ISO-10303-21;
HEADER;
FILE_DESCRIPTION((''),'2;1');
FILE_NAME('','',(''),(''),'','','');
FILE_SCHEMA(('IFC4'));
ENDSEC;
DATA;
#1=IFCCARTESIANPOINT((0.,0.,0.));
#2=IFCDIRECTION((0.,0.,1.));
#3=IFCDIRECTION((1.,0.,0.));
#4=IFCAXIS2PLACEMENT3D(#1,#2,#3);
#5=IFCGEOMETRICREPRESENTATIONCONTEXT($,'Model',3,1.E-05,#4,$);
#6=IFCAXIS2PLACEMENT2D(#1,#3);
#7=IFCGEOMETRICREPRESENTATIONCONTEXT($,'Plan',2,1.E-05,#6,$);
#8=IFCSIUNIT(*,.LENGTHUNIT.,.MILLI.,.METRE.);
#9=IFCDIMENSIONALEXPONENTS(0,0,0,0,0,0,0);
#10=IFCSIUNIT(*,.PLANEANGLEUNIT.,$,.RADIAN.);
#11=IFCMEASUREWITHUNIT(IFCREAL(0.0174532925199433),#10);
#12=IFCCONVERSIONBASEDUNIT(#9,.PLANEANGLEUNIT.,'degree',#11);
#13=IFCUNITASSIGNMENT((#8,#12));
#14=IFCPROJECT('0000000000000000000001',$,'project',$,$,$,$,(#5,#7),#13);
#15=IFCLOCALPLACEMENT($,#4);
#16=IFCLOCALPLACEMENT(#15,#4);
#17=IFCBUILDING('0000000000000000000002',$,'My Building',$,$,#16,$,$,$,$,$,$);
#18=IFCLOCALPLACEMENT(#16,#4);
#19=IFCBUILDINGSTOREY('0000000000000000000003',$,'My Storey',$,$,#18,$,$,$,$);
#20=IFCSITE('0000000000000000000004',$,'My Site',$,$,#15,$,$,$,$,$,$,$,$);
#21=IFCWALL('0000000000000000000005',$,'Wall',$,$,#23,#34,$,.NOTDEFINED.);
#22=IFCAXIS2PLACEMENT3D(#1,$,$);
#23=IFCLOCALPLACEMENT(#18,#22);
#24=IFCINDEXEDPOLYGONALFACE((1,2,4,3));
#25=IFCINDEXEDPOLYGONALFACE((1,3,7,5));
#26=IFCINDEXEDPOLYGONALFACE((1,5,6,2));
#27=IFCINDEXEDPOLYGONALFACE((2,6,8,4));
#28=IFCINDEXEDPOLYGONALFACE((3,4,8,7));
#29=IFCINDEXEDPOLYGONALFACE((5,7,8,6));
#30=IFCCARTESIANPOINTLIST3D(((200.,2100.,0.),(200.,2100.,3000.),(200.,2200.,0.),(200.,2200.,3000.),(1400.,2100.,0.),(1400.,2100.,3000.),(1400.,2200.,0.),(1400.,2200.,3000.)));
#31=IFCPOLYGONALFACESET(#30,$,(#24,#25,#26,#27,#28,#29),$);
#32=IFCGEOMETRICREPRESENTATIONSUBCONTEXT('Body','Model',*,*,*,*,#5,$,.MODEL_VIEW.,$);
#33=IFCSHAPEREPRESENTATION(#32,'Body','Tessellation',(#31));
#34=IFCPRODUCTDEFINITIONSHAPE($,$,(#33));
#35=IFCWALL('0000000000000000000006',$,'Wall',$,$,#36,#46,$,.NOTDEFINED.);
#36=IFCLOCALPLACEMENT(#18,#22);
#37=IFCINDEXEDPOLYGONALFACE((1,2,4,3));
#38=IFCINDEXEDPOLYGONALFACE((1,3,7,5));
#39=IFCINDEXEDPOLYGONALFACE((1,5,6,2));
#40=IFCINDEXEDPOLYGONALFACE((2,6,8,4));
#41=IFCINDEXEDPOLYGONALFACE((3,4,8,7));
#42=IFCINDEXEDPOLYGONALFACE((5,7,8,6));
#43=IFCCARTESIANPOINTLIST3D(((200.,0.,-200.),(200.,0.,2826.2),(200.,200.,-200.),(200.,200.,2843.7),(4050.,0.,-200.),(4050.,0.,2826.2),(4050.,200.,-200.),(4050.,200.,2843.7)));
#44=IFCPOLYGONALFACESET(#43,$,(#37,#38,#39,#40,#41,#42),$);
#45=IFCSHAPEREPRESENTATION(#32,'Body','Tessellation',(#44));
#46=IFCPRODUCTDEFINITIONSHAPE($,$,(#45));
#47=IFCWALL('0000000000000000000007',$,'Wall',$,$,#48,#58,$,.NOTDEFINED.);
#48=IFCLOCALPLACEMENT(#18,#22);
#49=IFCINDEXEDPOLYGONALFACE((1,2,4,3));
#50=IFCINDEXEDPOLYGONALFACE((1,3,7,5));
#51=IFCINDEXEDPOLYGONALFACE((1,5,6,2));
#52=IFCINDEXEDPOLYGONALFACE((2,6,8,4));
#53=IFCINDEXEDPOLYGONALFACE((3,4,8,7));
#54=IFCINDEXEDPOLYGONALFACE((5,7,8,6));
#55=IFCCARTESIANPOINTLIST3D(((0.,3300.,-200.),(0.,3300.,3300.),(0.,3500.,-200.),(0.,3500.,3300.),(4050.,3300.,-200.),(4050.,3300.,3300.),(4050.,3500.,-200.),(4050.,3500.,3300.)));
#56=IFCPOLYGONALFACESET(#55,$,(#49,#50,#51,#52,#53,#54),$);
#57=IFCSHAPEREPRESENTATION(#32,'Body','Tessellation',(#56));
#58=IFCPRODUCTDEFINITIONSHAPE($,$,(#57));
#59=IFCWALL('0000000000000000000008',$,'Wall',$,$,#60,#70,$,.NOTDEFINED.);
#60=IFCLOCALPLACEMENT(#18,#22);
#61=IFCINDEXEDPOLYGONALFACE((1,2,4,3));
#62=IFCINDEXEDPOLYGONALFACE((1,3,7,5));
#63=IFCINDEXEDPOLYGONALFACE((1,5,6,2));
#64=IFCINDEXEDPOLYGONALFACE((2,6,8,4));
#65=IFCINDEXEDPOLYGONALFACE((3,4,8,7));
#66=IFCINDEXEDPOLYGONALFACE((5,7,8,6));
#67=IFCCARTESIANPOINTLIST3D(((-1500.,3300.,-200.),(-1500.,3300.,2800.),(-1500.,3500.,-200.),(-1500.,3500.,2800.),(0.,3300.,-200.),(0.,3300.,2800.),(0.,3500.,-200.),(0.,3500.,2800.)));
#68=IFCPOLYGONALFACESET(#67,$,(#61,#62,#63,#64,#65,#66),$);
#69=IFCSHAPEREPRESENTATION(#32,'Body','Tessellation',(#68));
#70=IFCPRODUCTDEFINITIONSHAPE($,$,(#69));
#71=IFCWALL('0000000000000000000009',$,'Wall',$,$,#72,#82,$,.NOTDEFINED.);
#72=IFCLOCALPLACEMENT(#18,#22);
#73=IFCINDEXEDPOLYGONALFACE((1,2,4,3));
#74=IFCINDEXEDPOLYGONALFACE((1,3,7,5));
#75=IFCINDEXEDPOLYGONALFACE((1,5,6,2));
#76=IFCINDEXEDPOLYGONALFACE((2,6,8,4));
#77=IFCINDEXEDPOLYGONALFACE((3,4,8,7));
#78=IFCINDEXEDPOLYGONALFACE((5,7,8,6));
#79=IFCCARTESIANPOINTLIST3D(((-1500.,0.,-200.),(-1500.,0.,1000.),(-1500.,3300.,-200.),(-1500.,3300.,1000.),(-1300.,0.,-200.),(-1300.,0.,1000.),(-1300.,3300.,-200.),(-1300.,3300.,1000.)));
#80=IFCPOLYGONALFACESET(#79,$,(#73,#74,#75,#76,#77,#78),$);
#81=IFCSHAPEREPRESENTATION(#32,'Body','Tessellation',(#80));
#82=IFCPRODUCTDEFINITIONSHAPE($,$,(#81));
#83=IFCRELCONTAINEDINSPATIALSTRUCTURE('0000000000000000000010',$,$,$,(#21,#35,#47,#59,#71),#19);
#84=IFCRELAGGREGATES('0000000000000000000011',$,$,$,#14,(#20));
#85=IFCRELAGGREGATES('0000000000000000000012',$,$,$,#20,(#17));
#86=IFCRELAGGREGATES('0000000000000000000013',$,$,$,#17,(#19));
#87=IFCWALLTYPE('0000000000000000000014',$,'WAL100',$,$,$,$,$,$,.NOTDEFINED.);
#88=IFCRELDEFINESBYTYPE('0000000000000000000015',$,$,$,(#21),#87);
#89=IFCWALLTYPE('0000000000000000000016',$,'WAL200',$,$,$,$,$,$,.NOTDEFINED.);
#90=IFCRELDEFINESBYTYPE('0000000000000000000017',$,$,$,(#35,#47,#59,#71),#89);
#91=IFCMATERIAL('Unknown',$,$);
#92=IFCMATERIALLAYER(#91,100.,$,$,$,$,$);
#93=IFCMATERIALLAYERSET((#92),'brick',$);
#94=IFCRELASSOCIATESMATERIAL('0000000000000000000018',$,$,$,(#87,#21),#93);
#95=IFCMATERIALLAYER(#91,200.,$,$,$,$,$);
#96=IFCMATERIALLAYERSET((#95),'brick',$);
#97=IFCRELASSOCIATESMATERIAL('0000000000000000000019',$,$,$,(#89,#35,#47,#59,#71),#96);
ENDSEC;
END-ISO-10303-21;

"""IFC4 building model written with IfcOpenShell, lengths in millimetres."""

from ifc_helpers import new_model, entity, si_unit, converted_unit, frame, frame_2d, origin_with_axes, place, context, subcontext, project, spatial, indexed_curve, outline, extrude, clip, halfspace, material, layer, layer_set, layer_usage, type_object, element, save


model = new_model("IFC4")

# Units and contexts
model_context = context("Model", 3, precision=1e-05, world=origin_with_axes())
plan_context = context("Plan", 2, precision=1e-05, world=frame_2d((0.0, 0.0, 0.0), x_axis=(1.0, 0.0, 0.0)))
body_context = subcontext(model_context, "Body", "Model", "MODEL_VIEW")
ifc_project = project(units=[si_unit("LENGTHUNIT", "METRE", prefix="MILLI"), converted_unit("PLANEANGLEUNIT", "degree", entity("IfcReal", 0.0174532925199433), si_unit("PLANEANGLEUNIT", "RADIAN"), dimensions=[0, 0, 0, 0, 0, 0, 0])], contexts=[model_context, plan_context])

# Site, building, storey
site_placement = place(None, origin_with_axes())
site = spatial("IfcSite", under=ifc_project, at=site_placement, Name="My Site")
building_placement = place(site_placement, origin_with_axes())
building = spatial("IfcBuilding", under=site, at=building_placement, Name="My Building")
storey_placement = place(building_placement, origin_with_axes())
storey = spatial("IfcBuildingStorey", under=building, at=storey_placement, Name="My Storey")

# Shared definitions
ifc_material = material(Name="Unknown")

# Walls
ifc_layer_1 = layer(ifc_material, 100.0)
ifc_layer_set_1 = layer_set([ifc_layer_1], Name="brick")
ifc_layer_usage_1 = layer_usage(ifc_layer_set_1, "AXIS2", "POSITIVE", 0.0)
wall_type_1 = type_object("IfcWallType", Name="WAL100", PredefinedType="NOTDEFINED", material=ifc_layer_set_1)
wall_1_placement = place(storey_placement, frame((200.0, 2100.0, 0.0), z_axis=(0.0, 0.0, 1.0), x_axis=(1.0, 0.0, 0.0)))
element("IfcWall", 1, at=wall_1_placement, inside=storey, type_object=wall_type_1, material=ifc_layer_usage_1, Name="Wall", PredefinedType="NOTDEFINED", context=body_context, shape_type="SweptSolid", body=[
    extrude(outline(indexed_curve([(0.0, 0.0), (0.0, 100.0), (1200.0, 100.0), (1200.0, 0.0), (0.0, 0.0)], self_intersect=False)), origin_with_axes(), (0.0, 0.0, 1.0), 3000.0),
])
ifc_layer_2 = layer(ifc_material, 200.0)
ifc_layer_set_2 = layer_set([ifc_layer_2], Name="brick")
ifc_layer_usage_2 = layer_usage(ifc_layer_set_2, "AXIS2", "POSITIVE", 0.0)
wall_type_2 = type_object("IfcWallType", Name="WAL200", PredefinedType="NOTDEFINED", material=ifc_layer_set_2)
wall_2_placement = place(storey_placement, frame((200.0, 0.0, -200.0), z_axis=(0.0, 0.0, 1.0), x_axis=(1.0, 0.0, 0.0)))
element("IfcWall", 2, at=wall_2_placement, inside=storey, type_object=wall_type_2, material=ifc_layer_usage_2, Name="Wall", PredefinedType="NOTDEFINED", context=body_context, shape_type="Clipping", body=[
    clip(extrude(outline(indexed_curve([(0.0, 0.0), (0.0, 200.0), (3850.0, 200.0), (3850.0, 0.0), (0.0, 0.0)], self_intersect=False)), origin_with_axes(), (0.0, 0.0, 1.0), 3043.7), halfspace(frame((0.0, 200.0, 3043.7), z_axis=(0.0, -0.087156, 0.996195), x_axis=(1.0, 0.0, 0.0)), False)),
])
ifc_layer_usage_3 = layer_usage(ifc_layer_set_2, "AXIS2", "POSITIVE", 0.0)
wall_3_placement = place(storey_placement, frame((4050.0, 3500.0, -200.0), z_axis=(0.0, 0.0, 1.0), x_axis=(-1.0, 0.0, 0.0)))
element("IfcWall", 3, at=wall_3_placement, inside=storey, type_object=wall_type_2, material=ifc_layer_usage_3, Name="Wall", PredefinedType="NOTDEFINED", context=body_context, shape_type="SweptSolid", body=[
    extrude(outline(indexed_curve([(0.0, 0.0), (0.0, 200.0), (4050.0, 200.0), (4050.0, 0.0), (0.0, 0.0)], self_intersect=False)), origin_with_axes(), (0.0, 0.0, 1.0), 3500.0),
])
ifc_layer_usage_4 = layer_usage(ifc_layer_set_2, "AXIS2", "POSITIVE", 0.0)
wall_4_placement = place(storey_placement, frame((0.0, 3500.0, -200.0), z_axis=(0.0, 0.0, 1.0), x_axis=(-1.0, 0.0, 0.0)))
element("IfcWall", 4, at=wall_4_placement, inside=storey, type_object=wall_type_2, material=ifc_layer_usage_4, Name="Wall", PredefinedType="NOTDEFINED", context=body_context, shape_type="SweptSolid", body=[
    extrude(outline(indexed_curve([(0.0, 0.0), (0.0, 200.0), (1500.0, 200.0), (1500.0, 0.0), (0.0, 0.0)], self_intersect=False)), origin_with_axes(), (0.0, 0.0, 1.0), 3000.0),
])
ifc_layer_usage_5 = layer_usage(ifc_layer_set_2, "AXIS2", "POSITIVE", 0.0)
wall_5_placement = place(storey_placement, frame((-1500.0, 3300.0, -200.0), z_axis=(0.0, 0.0, 1.0), x_axis=(0.0, -1.0, 0.0)))
element("IfcWall", 5, at=wall_5_placement, inside=storey, type_object=wall_type_2, material=ifc_layer_usage_5, Name="Wall", PredefinedType="NOTDEFINED", context=body_context, shape_type="SweptSolid", body=[
    extrude(outline(indexed_curve([(0.0, 0.0), (0.0, 200.0), (3300.0, 200.0), (3300.0, 0.0), (0.0, 0.0)], self_intersect=False)), origin_with_axes(), (0.0, 0.0, 1.0), 1200.0),
])

save(model, "model.ifc")
